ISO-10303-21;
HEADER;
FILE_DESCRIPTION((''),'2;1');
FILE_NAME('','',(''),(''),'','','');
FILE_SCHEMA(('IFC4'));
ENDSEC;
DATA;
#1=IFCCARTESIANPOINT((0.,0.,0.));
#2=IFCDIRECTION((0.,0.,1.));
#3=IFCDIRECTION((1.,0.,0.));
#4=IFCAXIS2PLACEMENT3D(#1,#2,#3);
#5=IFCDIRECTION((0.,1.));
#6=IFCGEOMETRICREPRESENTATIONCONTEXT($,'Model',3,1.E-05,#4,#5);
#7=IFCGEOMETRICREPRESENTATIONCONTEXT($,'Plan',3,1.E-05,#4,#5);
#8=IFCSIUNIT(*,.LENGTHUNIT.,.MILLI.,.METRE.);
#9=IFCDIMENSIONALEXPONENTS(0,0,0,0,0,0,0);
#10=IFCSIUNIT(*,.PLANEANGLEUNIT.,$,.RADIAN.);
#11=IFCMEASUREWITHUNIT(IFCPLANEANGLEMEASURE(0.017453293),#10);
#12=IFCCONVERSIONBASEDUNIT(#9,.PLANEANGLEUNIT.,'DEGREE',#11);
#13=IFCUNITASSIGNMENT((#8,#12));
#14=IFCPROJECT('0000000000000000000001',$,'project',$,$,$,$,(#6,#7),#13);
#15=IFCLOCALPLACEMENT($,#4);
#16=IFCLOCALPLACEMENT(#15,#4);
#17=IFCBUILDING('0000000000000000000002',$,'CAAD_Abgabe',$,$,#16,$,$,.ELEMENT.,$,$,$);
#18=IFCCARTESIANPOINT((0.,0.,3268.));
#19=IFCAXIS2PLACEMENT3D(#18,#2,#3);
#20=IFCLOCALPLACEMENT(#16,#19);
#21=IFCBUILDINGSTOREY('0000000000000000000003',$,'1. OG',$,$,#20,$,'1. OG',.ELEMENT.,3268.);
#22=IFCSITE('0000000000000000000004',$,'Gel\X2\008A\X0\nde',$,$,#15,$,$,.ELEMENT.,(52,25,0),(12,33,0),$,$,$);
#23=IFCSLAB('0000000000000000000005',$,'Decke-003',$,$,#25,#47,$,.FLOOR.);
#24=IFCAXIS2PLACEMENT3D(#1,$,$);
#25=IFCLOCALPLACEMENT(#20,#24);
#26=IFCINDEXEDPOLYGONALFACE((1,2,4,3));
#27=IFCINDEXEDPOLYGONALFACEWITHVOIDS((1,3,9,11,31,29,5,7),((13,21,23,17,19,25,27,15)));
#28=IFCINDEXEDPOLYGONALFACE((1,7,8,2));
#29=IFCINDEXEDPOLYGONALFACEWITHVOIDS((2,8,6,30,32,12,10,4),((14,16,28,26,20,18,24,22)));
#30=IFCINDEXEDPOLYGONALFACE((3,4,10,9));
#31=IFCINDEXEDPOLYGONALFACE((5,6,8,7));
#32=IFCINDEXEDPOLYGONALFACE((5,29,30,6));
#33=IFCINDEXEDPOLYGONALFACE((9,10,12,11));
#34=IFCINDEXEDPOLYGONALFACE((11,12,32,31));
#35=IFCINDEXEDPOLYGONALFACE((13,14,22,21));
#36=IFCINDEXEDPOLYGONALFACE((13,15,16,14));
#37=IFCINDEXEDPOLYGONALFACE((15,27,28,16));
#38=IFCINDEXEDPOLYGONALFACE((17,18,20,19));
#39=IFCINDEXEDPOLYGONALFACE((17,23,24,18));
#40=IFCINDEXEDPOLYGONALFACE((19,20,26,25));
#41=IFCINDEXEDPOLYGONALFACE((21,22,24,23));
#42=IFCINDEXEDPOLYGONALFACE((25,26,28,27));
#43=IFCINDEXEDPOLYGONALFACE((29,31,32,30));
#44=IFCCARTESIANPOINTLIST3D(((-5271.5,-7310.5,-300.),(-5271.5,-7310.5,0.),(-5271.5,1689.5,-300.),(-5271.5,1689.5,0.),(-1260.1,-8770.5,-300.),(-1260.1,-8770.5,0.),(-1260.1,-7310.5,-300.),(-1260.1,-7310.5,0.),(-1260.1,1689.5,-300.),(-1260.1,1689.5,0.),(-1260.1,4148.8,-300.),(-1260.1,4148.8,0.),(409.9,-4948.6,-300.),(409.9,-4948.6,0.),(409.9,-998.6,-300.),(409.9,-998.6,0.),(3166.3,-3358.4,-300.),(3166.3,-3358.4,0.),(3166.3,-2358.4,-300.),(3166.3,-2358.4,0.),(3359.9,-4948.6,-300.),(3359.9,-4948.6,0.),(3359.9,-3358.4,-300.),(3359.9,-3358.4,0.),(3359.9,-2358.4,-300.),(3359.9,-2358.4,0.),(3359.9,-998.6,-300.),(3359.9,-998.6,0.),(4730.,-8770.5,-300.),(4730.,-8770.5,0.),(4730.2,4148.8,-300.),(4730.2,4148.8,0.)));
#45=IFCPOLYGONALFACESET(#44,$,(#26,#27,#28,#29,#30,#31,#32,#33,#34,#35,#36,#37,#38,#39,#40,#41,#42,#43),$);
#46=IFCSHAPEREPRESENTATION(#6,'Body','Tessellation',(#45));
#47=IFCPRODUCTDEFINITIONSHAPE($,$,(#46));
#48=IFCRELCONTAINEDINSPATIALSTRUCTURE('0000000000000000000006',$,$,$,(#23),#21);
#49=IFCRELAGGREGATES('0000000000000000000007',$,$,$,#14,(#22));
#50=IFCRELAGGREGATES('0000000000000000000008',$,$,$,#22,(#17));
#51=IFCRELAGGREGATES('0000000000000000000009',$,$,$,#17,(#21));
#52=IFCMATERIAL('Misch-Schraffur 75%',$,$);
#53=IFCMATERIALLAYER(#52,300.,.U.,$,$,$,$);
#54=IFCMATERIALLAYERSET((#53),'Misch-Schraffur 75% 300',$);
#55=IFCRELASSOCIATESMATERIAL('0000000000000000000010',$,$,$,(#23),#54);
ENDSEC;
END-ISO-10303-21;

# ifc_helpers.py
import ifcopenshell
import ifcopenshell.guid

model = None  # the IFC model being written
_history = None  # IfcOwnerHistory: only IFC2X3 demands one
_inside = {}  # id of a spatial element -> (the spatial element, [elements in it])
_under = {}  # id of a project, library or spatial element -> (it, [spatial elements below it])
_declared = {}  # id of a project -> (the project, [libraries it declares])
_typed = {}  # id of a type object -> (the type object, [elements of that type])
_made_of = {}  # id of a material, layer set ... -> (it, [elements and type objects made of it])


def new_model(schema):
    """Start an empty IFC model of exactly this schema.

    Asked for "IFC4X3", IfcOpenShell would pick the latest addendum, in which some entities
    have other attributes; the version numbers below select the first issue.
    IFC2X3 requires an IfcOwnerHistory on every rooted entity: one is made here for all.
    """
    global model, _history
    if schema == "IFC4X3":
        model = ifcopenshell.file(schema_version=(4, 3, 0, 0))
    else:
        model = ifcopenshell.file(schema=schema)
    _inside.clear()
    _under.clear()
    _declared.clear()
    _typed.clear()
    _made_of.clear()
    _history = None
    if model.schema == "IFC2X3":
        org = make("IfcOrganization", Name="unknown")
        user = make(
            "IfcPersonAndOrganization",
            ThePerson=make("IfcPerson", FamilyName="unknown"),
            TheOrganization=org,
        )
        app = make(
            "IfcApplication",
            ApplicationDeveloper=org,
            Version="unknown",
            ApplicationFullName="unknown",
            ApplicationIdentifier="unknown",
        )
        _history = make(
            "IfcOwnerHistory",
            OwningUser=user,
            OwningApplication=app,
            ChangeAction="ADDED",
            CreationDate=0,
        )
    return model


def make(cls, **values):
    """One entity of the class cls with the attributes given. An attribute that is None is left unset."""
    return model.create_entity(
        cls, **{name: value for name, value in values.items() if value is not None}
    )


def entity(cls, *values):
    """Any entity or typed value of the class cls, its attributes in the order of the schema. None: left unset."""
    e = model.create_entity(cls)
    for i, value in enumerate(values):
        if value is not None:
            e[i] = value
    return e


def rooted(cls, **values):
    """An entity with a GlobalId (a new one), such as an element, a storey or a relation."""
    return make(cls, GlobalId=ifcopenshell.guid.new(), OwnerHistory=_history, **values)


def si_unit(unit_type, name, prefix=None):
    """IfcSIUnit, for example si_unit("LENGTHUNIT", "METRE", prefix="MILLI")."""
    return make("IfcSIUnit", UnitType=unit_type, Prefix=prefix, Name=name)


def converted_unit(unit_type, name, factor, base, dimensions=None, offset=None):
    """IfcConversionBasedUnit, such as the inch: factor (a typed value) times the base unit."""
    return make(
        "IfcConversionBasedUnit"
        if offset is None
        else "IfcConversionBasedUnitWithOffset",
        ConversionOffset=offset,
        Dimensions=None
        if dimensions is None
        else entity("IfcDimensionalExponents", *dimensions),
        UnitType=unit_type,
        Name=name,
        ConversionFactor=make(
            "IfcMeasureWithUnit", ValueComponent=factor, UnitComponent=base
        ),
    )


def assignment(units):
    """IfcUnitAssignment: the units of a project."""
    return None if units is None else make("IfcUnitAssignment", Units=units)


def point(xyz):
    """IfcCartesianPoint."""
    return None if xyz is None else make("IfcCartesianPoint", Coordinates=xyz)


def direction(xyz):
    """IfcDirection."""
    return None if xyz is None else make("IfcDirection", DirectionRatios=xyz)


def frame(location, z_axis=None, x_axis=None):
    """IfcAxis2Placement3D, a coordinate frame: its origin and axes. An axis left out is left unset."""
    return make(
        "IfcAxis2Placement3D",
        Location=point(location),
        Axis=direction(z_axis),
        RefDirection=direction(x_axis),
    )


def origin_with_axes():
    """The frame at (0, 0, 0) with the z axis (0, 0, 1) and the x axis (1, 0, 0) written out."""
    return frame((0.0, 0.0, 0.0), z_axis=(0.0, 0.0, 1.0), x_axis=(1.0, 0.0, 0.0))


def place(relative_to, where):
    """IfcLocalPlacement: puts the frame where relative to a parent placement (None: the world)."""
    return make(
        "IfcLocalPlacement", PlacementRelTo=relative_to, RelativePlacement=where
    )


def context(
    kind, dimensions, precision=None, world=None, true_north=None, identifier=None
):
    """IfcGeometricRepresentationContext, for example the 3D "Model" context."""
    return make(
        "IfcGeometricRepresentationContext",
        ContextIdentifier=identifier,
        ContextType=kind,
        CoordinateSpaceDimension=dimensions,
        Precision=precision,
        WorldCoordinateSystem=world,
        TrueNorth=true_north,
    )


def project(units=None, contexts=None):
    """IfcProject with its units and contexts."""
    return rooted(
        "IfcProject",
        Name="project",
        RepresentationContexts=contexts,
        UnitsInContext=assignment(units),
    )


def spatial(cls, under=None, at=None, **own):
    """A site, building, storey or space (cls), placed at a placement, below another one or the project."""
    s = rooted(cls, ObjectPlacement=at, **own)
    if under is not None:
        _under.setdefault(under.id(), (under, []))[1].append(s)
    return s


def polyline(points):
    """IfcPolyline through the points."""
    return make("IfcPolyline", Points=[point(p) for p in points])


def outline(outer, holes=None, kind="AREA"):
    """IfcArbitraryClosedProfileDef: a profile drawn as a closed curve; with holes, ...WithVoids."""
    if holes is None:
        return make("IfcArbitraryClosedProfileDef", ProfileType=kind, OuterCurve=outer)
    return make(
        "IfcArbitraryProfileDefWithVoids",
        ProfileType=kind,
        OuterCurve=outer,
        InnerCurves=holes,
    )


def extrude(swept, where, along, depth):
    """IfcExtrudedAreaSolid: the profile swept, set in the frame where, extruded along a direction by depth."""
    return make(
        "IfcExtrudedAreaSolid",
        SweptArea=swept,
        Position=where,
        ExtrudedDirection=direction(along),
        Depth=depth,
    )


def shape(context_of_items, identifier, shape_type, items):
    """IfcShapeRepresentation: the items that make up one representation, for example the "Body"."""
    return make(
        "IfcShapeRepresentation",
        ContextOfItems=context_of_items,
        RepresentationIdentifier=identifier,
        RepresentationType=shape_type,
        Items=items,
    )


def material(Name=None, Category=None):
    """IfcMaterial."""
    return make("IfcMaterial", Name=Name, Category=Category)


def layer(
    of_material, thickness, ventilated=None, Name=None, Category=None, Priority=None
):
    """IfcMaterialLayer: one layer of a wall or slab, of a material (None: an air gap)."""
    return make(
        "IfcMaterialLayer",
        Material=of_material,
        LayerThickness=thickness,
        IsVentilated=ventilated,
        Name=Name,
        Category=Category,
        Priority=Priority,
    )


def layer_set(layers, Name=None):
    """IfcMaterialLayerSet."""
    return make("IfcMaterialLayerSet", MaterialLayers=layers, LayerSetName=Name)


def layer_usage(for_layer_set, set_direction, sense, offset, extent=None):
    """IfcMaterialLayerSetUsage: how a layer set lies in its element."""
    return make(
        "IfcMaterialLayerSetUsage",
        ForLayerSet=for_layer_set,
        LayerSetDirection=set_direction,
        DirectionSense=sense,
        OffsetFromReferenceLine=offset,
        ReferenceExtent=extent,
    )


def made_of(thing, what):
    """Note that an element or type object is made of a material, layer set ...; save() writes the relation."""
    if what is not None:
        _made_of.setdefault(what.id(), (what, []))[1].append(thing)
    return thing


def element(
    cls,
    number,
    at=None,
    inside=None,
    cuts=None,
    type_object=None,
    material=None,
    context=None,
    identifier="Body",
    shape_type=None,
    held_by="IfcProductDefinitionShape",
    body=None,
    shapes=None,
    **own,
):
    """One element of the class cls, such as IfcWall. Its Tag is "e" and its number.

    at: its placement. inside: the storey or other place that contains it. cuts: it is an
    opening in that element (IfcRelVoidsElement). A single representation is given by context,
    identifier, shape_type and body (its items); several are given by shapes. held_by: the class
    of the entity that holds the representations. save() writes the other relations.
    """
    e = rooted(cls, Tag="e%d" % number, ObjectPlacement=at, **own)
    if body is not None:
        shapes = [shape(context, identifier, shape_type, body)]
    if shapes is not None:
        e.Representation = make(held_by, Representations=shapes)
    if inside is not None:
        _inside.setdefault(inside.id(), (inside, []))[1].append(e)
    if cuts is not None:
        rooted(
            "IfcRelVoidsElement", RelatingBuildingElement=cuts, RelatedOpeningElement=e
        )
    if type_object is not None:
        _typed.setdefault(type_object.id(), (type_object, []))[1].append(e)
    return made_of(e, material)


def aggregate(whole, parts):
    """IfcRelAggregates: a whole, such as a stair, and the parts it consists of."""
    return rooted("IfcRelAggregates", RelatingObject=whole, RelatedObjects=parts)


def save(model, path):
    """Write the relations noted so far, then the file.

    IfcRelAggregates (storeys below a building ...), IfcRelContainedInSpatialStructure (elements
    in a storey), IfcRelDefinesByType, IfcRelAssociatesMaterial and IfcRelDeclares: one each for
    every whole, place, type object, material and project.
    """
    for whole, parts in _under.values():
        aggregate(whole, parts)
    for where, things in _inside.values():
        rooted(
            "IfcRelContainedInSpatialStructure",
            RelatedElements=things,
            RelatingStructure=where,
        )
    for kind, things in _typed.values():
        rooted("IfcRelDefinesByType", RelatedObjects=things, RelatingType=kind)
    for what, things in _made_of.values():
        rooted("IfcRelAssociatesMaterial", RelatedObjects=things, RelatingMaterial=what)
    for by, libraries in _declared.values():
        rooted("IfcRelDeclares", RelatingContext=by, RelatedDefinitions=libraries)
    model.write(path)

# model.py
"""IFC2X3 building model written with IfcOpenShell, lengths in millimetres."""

from ifc_helpers import new_model, entity, si_unit, converted_unit, direction, frame, origin_with_axes, place, context, project, spatial, polyline, outline, extrude, material, layer, layer_set, layer_usage, element, save


model = new_model("IFC2X3")

# Units and contexts
model_context = context("Model", 3, precision=1e-05, world=origin_with_axes(), true_north=direction((0.0, 1.0)))
plan_context = context("Plan", 3, precision=1e-05, world=origin_with_axes(), true_north=direction((0.0, 1.0)))
ifc_project = project(units=[si_unit("LENGTHUNIT", "METRE", prefix="MILLI"), converted_unit("PLANEANGLEUNIT", "DEGREE", entity("IfcPlaneAngleMeasure", 0.017453293), si_unit("PLANEANGLEUNIT", "RADIAN"), dimensions=[0, 0, 0, 0, 0, 0, 0])], contexts=[model_context, plan_context])

# Site, building, storey
site_placement = place(None, origin_with_axes())
site = spatial("IfcSite", under=ifc_project, at=site_placement, Name="Gel\u008ande", CompositionType="ELEMENT", RefLatitude=(52, 25, 0), RefLongitude=(12, 33, 0))
building_placement = place(site_placement, origin_with_axes())
building = spatial("IfcBuilding", under=site, at=building_placement, Name="CAAD_Abgabe", CompositionType="ELEMENT")
storey_placement = place(building_placement, frame((0.0, 0.0, 3268.0), z_axis=(0.0, 0.0, 1.0), x_axis=(1.0, 0.0, 0.0)))
storey = spatial("IfcBuildingStorey", under=building, at=storey_placement, Name="1. OG", LongName="1. OG", CompositionType="ELEMENT", Elevation=3268.0)

# Slab, opening
ifc_material = material(Name="Misch-Schraffur 75%")
ifc_layer = layer(ifc_material, 300.0, ventilated="UNKNOWN")
ifc_layer_set = layer_set([ifc_layer], Name="Misch-Schraffur 75% 300")
ifc_layer_usage = layer_usage(ifc_layer_set, "AXIS3", "NEGATIVE", 300.0)
slab_placement = place(storey_placement, frame((-5271.5, -7310.5, -300.0), z_axis=(0.0, 0.0, 1.0), x_axis=(1.0, 0.0, 0.0)))
slab = element("IfcSlab", 1, at=slab_placement, inside=storey, material=ifc_layer_usage, Name="Decke-003", PredefinedType="FLOOR", context=model_context, shape_type="SweptSolid", body=[
    extrude(outline(polyline([(0.0, 0.0), (4011.4, 0.0), (4011.4, -1460.0), (10001.5, -1460.0), (10001.7, 11459.3), (4011.4, 11459.3), (4011.4, 9000.0), (0.0, 9000.0), (0.0, 0.0)])), origin_with_axes(), (0.0, 0.0, 1.0), 300.0),
])
opening_placement = place(slab_placement, origin_with_axes())
element("IfcOpeningElement", 2, at=opening_placement, cuts=slab, context=model_context, shape_type="SweptSolid", body=[
    extrude(outline(polyline([(5681.4, 2361.9), (5681.4, 6311.9), (8631.4, 6311.9), (8631.4, 4952.1), (8437.8, 4952.1), (8437.8, 3952.1), (8631.4, 3952.1), (8631.4, 2361.9), (5681.4, 2361.9)])), origin_with_axes(), (0.0, 0.0, 1.0), 300.0),
])

save(model, "model.ifc")
